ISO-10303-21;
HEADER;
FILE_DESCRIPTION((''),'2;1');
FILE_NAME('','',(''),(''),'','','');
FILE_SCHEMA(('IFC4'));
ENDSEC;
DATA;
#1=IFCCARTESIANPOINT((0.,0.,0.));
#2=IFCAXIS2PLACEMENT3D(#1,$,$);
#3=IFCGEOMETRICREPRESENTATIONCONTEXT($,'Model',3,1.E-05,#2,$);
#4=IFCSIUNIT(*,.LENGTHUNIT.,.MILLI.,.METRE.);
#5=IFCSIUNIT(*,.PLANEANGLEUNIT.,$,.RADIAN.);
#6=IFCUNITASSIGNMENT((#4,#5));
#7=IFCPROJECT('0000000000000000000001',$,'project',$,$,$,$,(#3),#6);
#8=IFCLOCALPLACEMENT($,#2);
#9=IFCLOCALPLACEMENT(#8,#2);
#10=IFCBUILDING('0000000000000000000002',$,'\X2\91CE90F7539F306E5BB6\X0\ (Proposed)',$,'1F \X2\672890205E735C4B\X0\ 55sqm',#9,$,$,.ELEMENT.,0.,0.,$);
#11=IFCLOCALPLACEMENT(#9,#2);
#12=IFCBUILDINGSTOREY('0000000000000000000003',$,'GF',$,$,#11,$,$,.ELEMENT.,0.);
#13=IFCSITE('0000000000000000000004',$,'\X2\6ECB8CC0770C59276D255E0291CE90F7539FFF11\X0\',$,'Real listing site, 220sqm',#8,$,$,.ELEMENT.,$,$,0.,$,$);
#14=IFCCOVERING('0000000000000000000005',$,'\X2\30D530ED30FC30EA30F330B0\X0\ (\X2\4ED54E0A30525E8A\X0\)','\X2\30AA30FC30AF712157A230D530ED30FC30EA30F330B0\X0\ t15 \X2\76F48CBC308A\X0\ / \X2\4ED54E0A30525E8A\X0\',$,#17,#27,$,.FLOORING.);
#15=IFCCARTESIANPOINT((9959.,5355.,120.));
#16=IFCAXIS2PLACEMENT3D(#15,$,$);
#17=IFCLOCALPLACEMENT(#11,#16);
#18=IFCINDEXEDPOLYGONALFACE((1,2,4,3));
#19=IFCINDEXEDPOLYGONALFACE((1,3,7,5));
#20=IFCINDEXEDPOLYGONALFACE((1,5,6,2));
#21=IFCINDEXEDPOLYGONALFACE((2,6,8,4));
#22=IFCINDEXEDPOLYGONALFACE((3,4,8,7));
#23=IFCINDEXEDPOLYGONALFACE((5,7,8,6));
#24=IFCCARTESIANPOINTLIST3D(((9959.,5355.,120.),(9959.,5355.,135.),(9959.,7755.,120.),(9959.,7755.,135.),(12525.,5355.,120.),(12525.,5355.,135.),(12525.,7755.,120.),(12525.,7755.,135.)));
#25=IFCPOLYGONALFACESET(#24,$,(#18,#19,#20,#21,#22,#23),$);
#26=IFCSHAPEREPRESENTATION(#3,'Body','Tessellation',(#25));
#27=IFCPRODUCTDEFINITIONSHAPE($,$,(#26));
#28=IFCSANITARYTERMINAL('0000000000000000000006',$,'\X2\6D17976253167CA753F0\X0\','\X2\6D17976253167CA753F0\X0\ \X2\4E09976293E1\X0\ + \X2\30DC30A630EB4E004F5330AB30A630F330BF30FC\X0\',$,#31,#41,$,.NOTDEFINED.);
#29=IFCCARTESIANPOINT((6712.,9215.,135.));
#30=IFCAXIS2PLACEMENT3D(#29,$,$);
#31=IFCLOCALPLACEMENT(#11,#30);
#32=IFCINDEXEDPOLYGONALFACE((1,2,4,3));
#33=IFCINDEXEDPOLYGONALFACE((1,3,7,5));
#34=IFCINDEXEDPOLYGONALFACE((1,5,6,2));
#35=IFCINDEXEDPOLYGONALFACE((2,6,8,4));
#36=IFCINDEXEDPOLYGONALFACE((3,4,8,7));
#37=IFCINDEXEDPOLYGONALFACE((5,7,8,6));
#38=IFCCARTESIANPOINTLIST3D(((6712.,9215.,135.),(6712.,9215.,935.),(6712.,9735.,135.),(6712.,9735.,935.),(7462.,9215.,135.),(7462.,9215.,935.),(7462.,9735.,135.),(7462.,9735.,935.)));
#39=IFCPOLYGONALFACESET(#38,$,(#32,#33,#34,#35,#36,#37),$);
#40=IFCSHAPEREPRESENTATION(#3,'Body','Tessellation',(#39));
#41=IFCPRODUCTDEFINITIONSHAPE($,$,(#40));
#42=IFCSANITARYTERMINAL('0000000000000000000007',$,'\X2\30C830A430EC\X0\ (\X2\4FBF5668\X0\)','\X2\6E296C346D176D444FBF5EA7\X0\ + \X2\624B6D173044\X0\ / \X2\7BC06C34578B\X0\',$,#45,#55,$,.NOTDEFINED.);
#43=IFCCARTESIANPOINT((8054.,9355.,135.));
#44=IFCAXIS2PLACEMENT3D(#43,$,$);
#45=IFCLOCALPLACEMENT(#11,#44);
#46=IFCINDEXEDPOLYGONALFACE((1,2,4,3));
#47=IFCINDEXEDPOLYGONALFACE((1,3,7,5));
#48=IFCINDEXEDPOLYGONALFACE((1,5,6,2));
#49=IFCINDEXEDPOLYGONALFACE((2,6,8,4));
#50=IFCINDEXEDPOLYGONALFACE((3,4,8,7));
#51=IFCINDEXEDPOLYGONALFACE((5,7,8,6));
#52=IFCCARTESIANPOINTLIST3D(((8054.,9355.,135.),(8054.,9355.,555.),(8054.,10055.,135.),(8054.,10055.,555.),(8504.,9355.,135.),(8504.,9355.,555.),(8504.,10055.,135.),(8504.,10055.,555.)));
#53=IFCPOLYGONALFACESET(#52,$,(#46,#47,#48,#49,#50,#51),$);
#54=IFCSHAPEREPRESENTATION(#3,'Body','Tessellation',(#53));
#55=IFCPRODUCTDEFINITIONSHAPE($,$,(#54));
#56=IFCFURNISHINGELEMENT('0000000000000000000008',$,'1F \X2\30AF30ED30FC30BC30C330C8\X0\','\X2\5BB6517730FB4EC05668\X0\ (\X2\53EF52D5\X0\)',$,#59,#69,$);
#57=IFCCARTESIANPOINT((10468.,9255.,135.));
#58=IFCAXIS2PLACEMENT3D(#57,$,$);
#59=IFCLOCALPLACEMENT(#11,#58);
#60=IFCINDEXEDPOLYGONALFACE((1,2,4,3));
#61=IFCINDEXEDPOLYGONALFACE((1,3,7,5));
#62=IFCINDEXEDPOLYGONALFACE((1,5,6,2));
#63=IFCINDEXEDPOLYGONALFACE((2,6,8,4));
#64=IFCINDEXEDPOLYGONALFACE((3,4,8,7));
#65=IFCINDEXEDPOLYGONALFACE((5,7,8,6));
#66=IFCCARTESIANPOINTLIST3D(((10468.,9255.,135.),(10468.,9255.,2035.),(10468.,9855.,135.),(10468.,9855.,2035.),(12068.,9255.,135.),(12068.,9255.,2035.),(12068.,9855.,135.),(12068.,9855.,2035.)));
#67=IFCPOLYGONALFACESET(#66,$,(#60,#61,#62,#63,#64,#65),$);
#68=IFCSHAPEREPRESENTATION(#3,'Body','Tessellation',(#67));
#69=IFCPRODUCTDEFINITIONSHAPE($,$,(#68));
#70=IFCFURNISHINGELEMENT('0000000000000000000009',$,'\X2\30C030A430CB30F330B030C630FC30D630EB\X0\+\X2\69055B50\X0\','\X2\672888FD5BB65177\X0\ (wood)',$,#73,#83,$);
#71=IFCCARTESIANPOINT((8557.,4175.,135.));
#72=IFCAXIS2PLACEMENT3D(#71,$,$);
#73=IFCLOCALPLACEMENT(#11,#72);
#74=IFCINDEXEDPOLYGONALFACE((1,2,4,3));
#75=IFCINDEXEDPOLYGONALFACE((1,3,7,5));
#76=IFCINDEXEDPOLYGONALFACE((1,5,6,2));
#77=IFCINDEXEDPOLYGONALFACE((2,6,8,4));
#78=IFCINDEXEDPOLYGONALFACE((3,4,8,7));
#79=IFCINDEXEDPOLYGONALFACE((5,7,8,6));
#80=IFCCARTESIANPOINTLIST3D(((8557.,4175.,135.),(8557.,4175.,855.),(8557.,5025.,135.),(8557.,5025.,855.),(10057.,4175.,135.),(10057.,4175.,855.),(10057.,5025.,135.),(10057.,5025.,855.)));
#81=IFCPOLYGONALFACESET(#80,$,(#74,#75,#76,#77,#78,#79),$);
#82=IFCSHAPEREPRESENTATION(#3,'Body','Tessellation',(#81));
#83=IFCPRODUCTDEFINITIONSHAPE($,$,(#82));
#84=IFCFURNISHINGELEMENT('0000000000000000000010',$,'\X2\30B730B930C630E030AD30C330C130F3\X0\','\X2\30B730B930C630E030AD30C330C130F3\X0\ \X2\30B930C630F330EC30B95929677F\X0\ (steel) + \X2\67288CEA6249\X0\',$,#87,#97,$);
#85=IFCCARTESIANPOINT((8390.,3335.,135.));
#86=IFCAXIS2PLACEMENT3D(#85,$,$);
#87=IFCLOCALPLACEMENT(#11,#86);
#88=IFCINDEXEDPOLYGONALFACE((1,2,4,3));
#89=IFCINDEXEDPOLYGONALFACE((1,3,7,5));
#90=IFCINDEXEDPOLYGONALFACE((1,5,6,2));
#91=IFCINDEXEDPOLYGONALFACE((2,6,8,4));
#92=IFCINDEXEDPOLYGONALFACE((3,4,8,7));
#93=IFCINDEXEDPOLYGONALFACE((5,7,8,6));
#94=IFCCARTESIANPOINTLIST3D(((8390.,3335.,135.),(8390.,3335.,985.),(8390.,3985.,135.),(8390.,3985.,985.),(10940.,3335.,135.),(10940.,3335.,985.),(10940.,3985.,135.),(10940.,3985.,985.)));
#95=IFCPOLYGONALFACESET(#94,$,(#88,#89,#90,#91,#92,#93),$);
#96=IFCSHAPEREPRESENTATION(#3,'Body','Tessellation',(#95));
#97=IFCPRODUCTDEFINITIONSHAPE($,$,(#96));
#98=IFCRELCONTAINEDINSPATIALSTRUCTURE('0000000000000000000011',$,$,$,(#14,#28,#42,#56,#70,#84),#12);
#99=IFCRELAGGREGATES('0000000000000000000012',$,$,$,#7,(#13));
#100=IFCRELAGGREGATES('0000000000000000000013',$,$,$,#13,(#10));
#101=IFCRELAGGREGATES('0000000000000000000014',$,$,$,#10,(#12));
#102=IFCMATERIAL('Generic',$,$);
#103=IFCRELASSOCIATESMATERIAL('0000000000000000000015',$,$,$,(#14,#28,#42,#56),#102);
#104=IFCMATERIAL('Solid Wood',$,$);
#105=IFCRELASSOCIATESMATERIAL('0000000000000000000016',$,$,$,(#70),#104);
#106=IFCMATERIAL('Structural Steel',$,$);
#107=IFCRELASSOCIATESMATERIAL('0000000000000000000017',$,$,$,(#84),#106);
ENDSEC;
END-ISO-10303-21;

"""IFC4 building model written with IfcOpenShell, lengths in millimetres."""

from ifc_helpers import new_model, si_unit, frame, frame_2d, origin, place, context, project, spatial, rectangle, extrude, material, element, save


model = new_model("IFC4")

# Units and contexts
model_context = context("Model", 3, precision=1e-05, world=origin())
ifc_project = project(units=[si_unit("LENGTHUNIT", "METRE", prefix="MILLI"), si_unit("PLANEANGLEUNIT", "RADIAN")], contexts=[model_context])

# Site, building, storey
site_placement = place(None, origin())
site = spatial("IfcSite", under=ifc_project, at=site_placement, Name="滋賀県大津市野郷原１", ObjectType="Real listing site, 220sqm", CompositionType="ELEMENT", RefElevation=0.0)
building_placement = place(site_placement, origin())
building = spatial("IfcBuilding", under=site, at=building_placement, Name="野郷原の家 (Proposed)", ObjectType="1F 木造平屋 55sqm", CompositionType="ELEMENT", ElevationOfRefHeight=0.0, ElevationOfTerrain=0.0)
storey_placement = place(building_placement, origin())
storey = spatial("IfcBuildingStorey", under=building, at=storey_placement, Name="GF", CompositionType="ELEMENT", Elevation=0.0)

# Shared definitions
ifc_material_1 = material(Name="Solid Wood")

# Shared definitions
ifc_material_2 = material(Name="Structural Steel")

# Covering
ifc_material_3 = material(Name="Generic")
covering_placement = place(storey_placement, frame((9959.0, 5355.0, 120.0)))
element("IfcCovering", 1, at=covering_placement, inside=storey, material=ifc_material_3, Name="フローリング (仕上げ床)", Description="オーク無垢フローリング t15 直貼り / 仕上げ床", PredefinedType="FLOORING", context=model_context, shape_type="SweptSolid", body=[
    extrude(rectangle(XDim=2566.0, YDim=2400.0, at=frame_2d((1283.0, 1200.0))), frame((9959.0, 5355.0, 120.0)), (0.0, 0.0, 1.0), 15.0),
])

# Sanitary terminals
sanitary_terminal_1_placement = place(storey_placement, frame((6712.0, 9215.0, 135.0)))
element("IfcSanitaryTerminal", 2, at=sanitary_terminal_1_placement, inside=storey, material=ifc_material_3, Name="洗面化粧台", Description="洗面化粧台 三面鏡 + ボウル一体カウンター", PredefinedType="NOTDEFINED", context=model_context, shape_type="SweptSolid", body=[
    extrude(rectangle(XDim=750.0, YDim=520.0, at=frame_2d((375.0, 260.0))), frame((6712.0, 9215.0, 135.0)), (0.0, 0.0, 1.0), 800.0),
])
sanitary_terminal_2_placement = place(storey_placement, frame((8054.0, 9355.0, 135.0)))
element("IfcSanitaryTerminal", 3, at=sanitary_terminal_2_placement, inside=storey, material=ifc_material_3, Name="トイレ (便器)", Description="温水洗浄便座 + 手洗い / 節水型", PredefinedType="NOTDEFINED", context=model_context, shape_type="SweptSolid", body=[
    extrude(rectangle(XDim=450.0, YDim=700.0, at=frame_2d((225.0, 350.0))), frame((8054.0, 9355.0, 135.0)), (0.0, 0.0, 1.0), 420.0),
])

# Furnishing elements
furnishing_1_placement = place(storey_placement, frame((10468.0, 9255.0, 135.0)))
element("IfcFurnishingElement", 4, at=furnishing_1_placement, inside=storey, material=ifc_material_3, Name="1F クローゼット", Description="家具・什器 (可動)", context=model_context, shape_type="SweptSolid", body=[
    extrude(rectangle(XDim=1600.0, YDim=600.0, at=frame_2d((800.0, 300.0))), frame((10468.0, 9255.0, 135.0)), (0.0, 0.0, 1.0), 1900.0),
])
furnishing_2_placement = place(storey_placement, frame((8557.0, 4175.0, 135.0)))
element("IfcFurnishingElement", 5, at=furnishing_2_placement, inside=storey, material=ifc_material_1, Name="ダイニングテーブル+椅子", Description="木製家具 (wood)", context=model_context, shape_type="SweptSolid", body=[
    extrude(rectangle(XDim=1500.0, YDim=850.0, at=frame_2d((750.0, 425.0))), frame((8557.0, 4175.0, 135.0)), (0.0, 0.0, 1.0), 720.0),
])
furnishing_3_placement = place(storey_placement, frame((8390.0, 3335.0, 135.0)))
element("IfcFurnishingElement", 6, at=furnishing_3_placement, inside=storey, material=ifc_material_2, Name="システムキッチン", Description="システムキッチン ステンレス天板 (steel) + 木質扉", context=model_context, shape_type="SweptSolid", body=[
    extrude(rectangle(XDim=2550.0, YDim=650.0, at=frame_2d((1275.0, 325.0))), frame((8390.0, 3335.0, 135.0)), (0.0, 0.0, 1.0), 850.0),
])

save(model, "model.ifc")
